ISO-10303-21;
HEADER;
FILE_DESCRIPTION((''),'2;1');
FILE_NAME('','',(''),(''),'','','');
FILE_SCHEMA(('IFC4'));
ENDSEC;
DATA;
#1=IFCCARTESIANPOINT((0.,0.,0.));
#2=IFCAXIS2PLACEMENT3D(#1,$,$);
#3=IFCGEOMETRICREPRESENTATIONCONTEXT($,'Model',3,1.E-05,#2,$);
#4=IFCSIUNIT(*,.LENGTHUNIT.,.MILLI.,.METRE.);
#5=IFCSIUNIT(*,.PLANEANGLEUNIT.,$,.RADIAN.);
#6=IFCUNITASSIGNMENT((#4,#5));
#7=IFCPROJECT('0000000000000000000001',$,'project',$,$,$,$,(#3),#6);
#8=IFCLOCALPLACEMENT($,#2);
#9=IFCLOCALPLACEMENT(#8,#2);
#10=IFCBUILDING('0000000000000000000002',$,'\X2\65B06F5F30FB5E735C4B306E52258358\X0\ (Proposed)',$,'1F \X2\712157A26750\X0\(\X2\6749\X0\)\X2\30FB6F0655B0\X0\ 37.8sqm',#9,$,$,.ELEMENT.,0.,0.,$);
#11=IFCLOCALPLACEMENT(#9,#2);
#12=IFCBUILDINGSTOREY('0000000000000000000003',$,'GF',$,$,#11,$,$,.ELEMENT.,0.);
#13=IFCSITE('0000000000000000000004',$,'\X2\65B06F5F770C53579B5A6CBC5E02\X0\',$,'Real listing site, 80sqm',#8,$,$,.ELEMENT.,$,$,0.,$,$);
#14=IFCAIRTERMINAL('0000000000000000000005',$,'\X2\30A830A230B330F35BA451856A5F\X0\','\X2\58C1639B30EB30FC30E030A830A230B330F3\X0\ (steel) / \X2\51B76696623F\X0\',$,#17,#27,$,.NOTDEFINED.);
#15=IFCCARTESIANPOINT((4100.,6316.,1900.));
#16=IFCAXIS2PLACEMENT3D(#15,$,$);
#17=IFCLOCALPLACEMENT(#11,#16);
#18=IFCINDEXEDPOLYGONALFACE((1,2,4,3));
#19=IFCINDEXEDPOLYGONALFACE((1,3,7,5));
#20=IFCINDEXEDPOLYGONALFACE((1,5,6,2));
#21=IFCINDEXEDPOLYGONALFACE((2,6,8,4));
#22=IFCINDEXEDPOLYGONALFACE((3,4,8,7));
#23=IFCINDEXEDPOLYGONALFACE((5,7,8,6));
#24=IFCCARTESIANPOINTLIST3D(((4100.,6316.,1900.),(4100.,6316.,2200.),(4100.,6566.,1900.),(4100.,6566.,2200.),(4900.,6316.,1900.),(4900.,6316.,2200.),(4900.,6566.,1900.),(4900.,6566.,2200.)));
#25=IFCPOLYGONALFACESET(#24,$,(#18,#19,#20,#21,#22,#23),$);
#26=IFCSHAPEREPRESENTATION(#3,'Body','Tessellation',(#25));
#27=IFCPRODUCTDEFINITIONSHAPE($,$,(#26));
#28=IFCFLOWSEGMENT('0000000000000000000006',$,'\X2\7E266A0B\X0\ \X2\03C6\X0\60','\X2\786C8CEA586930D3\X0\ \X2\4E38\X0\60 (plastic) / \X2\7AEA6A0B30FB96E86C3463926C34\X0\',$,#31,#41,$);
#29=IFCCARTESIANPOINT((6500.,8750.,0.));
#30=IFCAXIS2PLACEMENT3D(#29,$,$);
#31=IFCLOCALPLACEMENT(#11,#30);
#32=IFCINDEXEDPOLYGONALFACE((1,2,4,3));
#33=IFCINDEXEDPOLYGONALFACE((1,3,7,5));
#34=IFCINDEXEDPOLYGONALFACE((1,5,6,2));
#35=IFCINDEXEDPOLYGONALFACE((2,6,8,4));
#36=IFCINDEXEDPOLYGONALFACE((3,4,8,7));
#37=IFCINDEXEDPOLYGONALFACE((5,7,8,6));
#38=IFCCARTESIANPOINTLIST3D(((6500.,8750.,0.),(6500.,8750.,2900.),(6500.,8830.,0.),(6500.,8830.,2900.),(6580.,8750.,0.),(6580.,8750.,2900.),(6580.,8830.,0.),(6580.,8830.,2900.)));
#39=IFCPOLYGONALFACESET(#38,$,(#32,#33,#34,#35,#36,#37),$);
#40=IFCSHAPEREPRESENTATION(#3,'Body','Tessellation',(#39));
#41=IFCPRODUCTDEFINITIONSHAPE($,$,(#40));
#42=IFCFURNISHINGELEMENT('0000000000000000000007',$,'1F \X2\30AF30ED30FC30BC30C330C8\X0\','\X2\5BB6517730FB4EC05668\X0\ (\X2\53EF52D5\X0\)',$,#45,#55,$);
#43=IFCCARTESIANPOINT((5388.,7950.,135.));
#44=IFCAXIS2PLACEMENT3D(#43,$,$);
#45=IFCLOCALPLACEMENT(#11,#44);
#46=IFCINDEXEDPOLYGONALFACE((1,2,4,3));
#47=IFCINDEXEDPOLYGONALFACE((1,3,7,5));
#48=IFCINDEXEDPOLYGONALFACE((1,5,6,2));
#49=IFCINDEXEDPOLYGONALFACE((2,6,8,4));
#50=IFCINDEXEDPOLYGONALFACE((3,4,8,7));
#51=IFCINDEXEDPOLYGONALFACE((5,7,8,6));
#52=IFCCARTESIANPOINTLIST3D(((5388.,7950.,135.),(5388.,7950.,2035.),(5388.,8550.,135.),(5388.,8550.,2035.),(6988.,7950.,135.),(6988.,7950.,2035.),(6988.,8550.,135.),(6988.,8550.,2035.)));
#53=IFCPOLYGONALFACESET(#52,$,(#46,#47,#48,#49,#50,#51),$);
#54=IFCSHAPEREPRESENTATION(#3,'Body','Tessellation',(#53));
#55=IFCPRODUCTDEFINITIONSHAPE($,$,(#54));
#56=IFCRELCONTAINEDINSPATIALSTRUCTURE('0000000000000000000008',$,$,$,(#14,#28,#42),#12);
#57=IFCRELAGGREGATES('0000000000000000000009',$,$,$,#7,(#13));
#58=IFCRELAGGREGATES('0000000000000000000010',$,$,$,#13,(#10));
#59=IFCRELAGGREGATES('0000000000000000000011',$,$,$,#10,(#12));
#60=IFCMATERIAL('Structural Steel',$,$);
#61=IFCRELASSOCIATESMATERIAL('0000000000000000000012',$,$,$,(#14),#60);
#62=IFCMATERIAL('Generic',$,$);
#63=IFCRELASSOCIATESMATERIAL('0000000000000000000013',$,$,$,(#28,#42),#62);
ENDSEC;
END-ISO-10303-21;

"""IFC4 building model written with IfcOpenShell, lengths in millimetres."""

from ifc_helpers import new_model, si_unit, frame, frame_2d, origin, place, context, project, spatial, rectangle, extrude, material, element, save


model = new_model("IFC4")

# Units and contexts
model_context = context("Model", 3, precision=1e-05, world=origin())
ifc_project = project(units=[si_unit("LENGTHUNIT", "METRE", prefix="MILLI"), si_unit("PLANEANGLEUNIT", "RADIAN")], contexts=[model_context])

# Site, building, storey
site_placement = place(None, origin())
site = spatial("IfcSite", under=ifc_project, at=site_placement, Name="新潟県南魚沼市", ObjectType="Real listing site, 80sqm", CompositionType="ELEMENT", RefElevation=0.0)
building_placement = place(site_placement, origin())
building = spatial("IfcBuilding", under=site, at=building_placement, Name="新潟・平屋の別荘 (Proposed)", ObjectType="1F 無垢材(杉)・漆喰 37.8sqm", CompositionType="ELEMENT", ElevationOfRefHeight=0.0, ElevationOfTerrain=0.0)
storey_placement = place(building_placement, origin())
storey = spatial("IfcBuildingStorey", under=building, at=storey_placement, Name="GF", CompositionType="ELEMENT", Elevation=0.0)

# Shared definitions
ifc_material_1 = material(Name="Structural Steel")

# Shared definitions
ifc_material_2 = material(Name="Generic")

# Air terminal
air_terminal_placement = place(storey_placement, frame((4100.0, 6316.0, 1900.0)))
element("IfcAirTerminal", 1, at=air_terminal_placement, inside=storey, material=ifc_material_1, Name="エアコン室内機", Description="壁掛ルームエアコン (steel) / 冷暖房", PredefinedType="NOTDEFINED", context=model_context, shape_type="SweptSolid", body=[
    extrude(rectangle(XDim=800.0, YDim=250.0, at=frame_2d((400.0, 125.0))), frame((4100.0, 6316.0, 1900.0)), (0.0, 0.0, 1.0), 300.0),
])

# Flow segment
flow_segment_placement = place(storey_placement, frame((6500.0, 8750.0, 0.0)))
element("IfcFlowSegment", 2, at=flow_segment_placement, inside=storey, material=ifc_material_2, Name="縦樋 φ60", Description="硬質塩ビ 丸60 (plastic) / 竪樋・雨水排水", context=model_context, shape_type="SweptSolid", body=[
    extrude(rectangle(XDim=80.0, YDim=80.0, at=frame_2d((40.0, 40.0))), frame((6500.0, 8750.0, 0.0)), (0.0, 0.0, 1.0), 2900.0),
])

# Furnishing element
furnishing_placement = place(storey_placement, frame((5388.0, 7950.0, 135.0)))
element("IfcFurnishingElement", 3, at=furnishing_placement, inside=storey, material=ifc_material_2, Name="1F クローゼット", Description="家具・什器 (可動)", context=model_context, shape_type="SweptSolid", body=[
    extrude(rectangle(XDim=1600.0, YDim=600.0, at=frame_2d((800.0, 300.0))), frame((5388.0, 7950.0, 135.0)), (0.0, 0.0, 1.0), 1900.0),
])

save(model, "model.ifc")
